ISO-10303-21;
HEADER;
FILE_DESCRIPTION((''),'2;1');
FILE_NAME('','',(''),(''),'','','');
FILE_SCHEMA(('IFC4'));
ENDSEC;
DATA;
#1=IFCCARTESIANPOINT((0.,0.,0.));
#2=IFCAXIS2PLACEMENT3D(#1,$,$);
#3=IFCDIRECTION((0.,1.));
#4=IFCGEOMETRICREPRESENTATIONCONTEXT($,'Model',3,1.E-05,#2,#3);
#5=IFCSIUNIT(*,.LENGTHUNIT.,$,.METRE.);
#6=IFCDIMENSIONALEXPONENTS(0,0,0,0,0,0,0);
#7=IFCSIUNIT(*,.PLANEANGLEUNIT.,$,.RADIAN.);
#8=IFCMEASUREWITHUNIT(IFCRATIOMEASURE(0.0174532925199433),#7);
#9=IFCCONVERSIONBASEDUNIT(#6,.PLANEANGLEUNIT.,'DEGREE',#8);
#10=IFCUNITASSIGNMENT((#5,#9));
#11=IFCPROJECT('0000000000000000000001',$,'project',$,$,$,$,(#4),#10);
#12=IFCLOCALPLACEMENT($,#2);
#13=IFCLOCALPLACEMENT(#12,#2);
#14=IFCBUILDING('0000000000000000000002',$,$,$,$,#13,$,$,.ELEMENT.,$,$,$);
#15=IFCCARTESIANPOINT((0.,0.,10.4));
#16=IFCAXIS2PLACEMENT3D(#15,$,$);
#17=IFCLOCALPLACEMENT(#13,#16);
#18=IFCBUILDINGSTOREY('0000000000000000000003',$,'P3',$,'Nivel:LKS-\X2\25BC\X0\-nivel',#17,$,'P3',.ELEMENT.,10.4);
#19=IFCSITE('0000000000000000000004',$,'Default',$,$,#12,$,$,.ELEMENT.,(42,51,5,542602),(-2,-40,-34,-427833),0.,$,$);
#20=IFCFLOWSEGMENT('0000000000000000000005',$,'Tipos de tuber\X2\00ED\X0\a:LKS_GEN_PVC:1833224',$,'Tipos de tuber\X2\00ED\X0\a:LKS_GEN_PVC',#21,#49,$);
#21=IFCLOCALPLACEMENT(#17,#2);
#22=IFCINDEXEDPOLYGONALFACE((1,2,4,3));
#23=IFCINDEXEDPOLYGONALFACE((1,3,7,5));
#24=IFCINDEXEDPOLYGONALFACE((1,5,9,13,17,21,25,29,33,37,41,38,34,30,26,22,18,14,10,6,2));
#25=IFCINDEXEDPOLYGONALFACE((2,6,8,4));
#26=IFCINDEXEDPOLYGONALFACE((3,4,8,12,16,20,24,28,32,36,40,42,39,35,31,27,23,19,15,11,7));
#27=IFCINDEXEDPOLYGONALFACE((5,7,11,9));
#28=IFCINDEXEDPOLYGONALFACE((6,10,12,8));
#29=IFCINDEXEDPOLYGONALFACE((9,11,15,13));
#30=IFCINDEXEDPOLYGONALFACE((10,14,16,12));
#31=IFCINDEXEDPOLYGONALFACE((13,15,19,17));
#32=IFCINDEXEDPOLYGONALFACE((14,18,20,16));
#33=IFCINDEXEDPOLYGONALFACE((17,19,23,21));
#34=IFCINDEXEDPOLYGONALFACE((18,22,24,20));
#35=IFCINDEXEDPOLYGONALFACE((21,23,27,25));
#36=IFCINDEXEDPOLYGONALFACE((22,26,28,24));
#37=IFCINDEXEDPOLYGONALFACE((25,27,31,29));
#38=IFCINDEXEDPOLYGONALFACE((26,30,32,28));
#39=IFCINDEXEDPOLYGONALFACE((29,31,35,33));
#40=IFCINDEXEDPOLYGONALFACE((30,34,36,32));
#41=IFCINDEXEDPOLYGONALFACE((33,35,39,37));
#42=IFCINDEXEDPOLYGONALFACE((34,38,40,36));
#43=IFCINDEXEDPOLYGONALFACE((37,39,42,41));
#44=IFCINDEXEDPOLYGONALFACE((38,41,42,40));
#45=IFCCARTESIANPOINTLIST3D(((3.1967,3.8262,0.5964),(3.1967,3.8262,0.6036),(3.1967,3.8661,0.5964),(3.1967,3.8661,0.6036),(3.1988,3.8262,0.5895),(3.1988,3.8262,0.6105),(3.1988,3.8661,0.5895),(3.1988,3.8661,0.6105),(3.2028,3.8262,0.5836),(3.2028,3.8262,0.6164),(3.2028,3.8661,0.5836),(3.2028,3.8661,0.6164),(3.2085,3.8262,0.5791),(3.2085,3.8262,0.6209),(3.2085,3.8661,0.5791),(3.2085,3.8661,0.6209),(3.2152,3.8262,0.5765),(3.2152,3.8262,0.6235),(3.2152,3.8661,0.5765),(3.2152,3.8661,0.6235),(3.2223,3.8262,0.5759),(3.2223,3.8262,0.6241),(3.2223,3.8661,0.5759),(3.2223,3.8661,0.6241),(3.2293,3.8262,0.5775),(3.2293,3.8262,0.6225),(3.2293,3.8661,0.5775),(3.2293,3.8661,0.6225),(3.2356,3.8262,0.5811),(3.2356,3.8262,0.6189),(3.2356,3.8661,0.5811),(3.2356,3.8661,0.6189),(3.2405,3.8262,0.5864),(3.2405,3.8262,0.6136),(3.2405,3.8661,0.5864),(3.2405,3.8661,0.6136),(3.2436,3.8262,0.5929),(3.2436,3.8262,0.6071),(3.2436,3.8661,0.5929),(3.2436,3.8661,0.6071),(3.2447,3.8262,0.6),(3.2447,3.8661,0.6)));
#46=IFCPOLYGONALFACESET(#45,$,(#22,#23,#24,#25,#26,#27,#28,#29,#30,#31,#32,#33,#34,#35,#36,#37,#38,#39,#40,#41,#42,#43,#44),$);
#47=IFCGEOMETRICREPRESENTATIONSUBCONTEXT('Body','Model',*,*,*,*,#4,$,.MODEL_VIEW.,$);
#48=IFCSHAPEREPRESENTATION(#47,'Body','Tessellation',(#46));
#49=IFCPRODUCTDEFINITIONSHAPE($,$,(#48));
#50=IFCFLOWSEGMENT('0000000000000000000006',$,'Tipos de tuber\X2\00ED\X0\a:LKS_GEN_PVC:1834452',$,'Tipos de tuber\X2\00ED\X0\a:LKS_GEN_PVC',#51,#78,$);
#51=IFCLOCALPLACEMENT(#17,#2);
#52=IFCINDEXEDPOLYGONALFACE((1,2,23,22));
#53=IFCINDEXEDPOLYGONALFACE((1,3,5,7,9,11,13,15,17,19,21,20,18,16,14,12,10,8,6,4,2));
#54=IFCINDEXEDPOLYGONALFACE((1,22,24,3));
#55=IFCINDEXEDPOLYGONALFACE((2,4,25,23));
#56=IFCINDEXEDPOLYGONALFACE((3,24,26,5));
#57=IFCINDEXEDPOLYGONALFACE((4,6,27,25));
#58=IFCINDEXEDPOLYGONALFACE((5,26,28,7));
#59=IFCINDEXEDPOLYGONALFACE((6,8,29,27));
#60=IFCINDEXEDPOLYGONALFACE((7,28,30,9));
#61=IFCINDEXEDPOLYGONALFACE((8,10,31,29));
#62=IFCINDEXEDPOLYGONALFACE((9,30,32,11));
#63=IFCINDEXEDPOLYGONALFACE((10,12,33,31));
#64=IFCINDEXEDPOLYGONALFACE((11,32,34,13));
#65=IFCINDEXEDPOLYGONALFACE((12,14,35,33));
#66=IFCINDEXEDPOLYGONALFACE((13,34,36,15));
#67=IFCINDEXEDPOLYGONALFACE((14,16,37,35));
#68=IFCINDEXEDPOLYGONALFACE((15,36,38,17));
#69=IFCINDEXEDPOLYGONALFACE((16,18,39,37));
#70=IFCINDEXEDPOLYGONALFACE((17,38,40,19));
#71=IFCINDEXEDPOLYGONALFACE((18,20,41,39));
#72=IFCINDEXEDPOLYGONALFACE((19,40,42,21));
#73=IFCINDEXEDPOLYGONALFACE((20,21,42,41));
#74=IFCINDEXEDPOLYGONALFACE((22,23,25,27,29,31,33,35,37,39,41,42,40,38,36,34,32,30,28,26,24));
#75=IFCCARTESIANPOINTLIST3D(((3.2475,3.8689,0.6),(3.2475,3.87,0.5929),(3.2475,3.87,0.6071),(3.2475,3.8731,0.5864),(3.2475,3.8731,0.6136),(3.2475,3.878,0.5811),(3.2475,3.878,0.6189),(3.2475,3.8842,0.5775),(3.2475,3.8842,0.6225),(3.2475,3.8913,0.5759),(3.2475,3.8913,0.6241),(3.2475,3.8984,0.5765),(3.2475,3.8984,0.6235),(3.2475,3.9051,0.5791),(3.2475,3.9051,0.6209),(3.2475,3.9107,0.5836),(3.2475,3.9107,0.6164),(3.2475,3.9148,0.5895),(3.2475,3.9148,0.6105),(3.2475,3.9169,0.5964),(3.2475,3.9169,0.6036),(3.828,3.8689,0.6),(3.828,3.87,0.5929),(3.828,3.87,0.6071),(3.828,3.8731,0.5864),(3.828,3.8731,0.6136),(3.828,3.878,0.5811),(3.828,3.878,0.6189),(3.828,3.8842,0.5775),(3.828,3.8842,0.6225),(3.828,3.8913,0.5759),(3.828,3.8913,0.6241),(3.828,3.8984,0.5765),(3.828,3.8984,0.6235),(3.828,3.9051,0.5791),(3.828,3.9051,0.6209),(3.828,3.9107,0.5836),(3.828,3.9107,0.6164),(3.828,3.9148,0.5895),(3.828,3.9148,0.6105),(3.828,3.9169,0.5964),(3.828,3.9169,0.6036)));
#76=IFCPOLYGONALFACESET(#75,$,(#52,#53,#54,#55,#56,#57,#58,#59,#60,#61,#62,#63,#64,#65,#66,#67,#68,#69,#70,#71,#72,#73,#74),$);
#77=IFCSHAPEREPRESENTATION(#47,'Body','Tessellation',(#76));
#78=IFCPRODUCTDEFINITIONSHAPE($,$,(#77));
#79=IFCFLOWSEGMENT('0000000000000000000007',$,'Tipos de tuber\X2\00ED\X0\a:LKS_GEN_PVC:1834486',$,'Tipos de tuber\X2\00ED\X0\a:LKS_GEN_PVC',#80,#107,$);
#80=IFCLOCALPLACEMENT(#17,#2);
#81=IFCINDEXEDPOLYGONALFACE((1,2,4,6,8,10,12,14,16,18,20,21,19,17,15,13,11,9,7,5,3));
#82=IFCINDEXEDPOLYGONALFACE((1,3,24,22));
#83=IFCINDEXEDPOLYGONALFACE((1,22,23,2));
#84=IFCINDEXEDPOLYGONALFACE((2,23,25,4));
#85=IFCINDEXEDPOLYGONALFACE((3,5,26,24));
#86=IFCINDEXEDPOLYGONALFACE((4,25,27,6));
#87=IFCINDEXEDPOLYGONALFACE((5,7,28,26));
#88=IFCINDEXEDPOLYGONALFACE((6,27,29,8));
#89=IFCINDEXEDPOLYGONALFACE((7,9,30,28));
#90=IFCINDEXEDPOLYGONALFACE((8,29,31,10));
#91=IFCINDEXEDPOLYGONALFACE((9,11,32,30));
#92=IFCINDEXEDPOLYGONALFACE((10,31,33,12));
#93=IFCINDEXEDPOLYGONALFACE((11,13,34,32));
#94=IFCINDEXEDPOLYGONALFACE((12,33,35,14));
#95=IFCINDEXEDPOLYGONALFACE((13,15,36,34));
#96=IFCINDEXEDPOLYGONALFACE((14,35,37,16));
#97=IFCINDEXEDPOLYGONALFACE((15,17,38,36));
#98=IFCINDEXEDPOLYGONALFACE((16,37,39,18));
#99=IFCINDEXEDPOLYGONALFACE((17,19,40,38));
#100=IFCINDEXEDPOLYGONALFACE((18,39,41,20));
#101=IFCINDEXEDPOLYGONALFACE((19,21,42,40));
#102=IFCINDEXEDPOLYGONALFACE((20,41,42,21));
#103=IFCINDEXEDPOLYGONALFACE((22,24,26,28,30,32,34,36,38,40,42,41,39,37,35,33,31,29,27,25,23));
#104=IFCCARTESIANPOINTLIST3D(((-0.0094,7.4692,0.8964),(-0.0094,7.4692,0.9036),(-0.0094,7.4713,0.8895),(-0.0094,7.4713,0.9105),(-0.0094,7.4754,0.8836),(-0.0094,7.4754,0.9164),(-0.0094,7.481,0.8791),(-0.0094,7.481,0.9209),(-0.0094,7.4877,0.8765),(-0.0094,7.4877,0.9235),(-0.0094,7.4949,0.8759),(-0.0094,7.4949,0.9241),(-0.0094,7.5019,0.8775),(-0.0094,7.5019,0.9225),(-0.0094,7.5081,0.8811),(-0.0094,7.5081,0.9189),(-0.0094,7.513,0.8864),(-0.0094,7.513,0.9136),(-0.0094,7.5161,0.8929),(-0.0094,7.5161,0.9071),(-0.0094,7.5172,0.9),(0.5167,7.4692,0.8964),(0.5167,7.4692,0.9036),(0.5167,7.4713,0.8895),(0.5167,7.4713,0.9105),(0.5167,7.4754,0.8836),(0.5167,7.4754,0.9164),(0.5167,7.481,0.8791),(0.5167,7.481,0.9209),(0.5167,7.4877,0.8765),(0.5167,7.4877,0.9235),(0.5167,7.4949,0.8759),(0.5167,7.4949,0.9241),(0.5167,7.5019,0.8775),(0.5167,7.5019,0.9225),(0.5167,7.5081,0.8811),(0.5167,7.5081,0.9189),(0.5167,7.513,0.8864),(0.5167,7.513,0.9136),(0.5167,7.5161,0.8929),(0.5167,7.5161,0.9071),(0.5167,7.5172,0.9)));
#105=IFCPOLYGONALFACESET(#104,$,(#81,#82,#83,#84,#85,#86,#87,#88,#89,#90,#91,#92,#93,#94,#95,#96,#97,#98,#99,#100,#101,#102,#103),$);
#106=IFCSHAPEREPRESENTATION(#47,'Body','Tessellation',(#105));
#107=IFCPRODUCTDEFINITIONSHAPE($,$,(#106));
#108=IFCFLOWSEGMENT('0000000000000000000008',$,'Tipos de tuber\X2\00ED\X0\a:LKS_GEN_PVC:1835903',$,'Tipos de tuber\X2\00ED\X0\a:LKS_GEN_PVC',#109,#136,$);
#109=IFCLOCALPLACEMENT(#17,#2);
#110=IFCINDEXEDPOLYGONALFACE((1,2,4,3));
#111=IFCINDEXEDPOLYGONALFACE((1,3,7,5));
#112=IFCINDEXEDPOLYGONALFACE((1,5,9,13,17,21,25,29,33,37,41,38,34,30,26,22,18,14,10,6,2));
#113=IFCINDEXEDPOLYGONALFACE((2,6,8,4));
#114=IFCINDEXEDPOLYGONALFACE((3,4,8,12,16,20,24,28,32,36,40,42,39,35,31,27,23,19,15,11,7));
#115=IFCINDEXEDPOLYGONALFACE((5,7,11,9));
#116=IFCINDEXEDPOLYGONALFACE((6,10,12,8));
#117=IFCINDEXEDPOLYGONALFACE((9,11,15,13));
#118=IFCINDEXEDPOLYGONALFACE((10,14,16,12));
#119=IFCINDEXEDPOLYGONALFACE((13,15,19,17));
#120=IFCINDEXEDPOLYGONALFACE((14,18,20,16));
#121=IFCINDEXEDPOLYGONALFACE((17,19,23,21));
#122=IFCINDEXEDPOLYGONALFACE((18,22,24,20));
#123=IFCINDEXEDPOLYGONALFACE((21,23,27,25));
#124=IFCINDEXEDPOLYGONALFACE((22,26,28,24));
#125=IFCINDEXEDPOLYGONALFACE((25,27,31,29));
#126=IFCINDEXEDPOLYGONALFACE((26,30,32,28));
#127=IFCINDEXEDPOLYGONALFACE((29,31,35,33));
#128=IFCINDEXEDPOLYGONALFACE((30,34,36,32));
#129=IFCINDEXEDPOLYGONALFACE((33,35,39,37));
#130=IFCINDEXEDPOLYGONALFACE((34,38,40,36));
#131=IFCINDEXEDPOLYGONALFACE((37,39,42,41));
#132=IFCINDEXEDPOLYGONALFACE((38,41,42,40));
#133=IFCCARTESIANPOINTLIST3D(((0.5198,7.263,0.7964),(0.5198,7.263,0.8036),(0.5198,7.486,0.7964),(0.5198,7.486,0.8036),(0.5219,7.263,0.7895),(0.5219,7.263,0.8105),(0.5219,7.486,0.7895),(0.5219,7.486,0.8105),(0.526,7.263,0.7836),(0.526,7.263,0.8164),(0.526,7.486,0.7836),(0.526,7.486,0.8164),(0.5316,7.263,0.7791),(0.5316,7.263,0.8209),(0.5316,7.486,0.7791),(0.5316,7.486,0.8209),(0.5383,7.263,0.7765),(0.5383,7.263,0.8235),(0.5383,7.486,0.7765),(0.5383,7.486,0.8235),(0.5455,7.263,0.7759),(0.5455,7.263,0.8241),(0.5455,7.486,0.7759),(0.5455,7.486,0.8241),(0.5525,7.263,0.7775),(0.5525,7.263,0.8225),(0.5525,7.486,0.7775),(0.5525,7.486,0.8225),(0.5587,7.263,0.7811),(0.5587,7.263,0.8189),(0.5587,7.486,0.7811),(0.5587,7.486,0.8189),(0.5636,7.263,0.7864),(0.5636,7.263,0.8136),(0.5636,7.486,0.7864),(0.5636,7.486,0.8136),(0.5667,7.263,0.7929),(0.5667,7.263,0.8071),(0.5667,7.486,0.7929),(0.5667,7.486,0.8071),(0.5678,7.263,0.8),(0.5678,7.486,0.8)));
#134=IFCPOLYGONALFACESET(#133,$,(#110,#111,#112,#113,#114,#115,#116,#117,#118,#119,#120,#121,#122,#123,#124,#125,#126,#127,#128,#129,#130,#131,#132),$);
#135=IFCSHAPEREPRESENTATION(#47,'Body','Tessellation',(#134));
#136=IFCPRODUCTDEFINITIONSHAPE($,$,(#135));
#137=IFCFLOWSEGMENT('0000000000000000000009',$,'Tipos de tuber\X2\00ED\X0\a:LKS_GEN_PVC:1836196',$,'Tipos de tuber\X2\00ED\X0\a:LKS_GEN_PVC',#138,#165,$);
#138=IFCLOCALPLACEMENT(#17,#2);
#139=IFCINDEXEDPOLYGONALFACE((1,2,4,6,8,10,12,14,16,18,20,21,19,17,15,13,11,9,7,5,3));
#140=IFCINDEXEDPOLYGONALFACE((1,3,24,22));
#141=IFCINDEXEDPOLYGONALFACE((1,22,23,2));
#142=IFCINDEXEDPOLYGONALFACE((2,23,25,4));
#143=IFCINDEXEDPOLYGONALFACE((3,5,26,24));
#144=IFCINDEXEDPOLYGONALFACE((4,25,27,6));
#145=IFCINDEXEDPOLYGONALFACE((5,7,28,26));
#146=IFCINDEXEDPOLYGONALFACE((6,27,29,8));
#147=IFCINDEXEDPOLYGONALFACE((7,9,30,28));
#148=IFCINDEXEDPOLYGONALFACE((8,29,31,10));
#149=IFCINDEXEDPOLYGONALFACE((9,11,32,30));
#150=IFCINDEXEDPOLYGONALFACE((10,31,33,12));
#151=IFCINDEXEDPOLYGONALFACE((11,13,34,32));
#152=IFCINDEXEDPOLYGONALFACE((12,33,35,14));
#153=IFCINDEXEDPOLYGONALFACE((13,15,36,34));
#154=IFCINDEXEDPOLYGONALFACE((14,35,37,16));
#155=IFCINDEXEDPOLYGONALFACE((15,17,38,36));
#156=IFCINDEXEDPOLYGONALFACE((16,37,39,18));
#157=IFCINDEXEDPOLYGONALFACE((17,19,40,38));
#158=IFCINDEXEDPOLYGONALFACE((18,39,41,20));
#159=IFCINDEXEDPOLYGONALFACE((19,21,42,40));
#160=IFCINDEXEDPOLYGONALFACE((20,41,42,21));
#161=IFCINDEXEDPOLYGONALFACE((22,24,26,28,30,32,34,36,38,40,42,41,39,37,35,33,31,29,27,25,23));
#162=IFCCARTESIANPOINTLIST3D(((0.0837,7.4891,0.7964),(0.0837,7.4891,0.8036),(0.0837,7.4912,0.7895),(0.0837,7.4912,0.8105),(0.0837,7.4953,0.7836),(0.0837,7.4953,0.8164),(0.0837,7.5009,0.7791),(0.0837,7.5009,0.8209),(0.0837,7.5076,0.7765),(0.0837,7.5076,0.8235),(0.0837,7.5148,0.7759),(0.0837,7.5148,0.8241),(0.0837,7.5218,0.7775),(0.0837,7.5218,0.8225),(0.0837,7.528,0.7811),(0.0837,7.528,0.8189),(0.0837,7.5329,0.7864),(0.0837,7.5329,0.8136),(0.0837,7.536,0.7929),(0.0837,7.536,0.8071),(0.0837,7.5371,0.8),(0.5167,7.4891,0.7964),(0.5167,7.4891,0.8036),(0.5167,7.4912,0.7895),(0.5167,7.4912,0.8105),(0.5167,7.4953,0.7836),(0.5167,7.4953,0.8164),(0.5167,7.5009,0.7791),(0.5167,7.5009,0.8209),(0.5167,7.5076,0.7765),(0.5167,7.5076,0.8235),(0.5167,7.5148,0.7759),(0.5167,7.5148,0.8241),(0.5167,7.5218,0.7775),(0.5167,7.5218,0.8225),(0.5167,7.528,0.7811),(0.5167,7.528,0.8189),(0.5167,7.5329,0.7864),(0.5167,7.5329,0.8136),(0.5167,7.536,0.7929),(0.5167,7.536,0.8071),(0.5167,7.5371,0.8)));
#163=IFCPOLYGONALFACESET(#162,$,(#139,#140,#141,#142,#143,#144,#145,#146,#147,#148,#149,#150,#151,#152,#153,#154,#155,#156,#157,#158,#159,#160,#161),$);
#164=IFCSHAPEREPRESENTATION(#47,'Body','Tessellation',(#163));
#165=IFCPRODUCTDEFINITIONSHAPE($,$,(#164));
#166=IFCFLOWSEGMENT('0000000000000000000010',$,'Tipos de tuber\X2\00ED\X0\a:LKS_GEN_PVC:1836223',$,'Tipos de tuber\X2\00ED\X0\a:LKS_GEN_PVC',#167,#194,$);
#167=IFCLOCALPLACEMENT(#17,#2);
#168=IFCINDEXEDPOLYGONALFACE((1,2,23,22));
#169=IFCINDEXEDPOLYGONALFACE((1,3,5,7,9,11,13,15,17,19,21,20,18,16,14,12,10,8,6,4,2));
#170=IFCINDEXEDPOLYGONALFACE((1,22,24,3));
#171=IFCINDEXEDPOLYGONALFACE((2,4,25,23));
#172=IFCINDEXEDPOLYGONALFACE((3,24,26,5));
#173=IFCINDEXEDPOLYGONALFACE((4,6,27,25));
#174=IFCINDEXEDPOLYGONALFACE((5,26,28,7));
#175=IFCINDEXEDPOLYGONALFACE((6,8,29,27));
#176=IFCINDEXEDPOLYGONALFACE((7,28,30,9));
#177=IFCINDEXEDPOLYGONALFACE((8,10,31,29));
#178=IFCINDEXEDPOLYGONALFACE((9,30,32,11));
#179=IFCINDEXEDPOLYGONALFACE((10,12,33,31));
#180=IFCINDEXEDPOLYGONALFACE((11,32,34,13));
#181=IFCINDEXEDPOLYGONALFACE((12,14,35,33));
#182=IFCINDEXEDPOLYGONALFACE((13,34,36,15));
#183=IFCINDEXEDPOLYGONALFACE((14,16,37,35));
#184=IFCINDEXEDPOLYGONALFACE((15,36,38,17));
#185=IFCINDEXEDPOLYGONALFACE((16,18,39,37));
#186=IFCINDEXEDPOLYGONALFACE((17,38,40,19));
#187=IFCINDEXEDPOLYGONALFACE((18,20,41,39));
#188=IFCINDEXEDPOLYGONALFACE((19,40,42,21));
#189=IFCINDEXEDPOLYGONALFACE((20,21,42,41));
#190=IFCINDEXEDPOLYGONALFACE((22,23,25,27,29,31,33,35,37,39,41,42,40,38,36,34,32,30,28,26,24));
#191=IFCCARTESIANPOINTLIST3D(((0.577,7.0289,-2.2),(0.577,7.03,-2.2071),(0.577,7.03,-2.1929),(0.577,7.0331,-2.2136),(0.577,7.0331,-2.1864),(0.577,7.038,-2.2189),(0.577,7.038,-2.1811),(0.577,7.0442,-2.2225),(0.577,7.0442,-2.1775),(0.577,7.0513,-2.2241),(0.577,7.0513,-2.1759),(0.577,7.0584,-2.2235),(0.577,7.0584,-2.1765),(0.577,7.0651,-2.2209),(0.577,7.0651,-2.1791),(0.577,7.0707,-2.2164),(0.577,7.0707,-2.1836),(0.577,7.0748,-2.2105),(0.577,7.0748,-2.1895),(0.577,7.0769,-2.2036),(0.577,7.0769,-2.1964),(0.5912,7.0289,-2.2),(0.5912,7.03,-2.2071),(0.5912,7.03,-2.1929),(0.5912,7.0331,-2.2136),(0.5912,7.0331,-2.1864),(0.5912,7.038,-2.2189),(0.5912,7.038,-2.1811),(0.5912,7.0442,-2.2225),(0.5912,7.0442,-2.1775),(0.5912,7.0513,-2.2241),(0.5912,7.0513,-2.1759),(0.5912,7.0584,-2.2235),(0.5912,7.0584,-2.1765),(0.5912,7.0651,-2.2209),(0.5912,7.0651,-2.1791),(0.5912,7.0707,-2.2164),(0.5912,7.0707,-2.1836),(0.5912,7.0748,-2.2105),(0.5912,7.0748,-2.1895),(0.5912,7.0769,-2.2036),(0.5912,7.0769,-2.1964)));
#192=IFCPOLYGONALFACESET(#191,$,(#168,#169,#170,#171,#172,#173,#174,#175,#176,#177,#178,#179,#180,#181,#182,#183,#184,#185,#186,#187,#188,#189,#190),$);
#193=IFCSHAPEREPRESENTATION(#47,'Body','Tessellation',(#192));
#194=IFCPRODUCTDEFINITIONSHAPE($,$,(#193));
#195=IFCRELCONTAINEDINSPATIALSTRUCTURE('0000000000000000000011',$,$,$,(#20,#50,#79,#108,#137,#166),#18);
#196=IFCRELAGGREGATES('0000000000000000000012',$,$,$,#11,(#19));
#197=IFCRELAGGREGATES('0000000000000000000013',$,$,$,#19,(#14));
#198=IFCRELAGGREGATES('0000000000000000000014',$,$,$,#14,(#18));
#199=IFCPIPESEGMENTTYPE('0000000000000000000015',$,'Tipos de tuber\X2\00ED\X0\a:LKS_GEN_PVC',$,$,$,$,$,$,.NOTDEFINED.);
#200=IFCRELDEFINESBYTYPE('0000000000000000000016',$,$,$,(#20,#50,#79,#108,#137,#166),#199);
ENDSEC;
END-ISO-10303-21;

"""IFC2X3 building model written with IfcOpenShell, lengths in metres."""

from ifc_helpers import new_model, entity, si_unit, converted_unit, direction, frame, frame_2d, origin, origin_2d_with_axis, place, context, subcontext, project, spatial, circle, extrude, type_object, element, save


model = new_model("IFC2X3")

# Units and contexts
model_context = context("Model", 3, precision=1e-05, world=origin(), true_north=direction((0.0, 1.0)))
body_context = subcontext(model_context, "Body", "Model", "MODEL_VIEW")
ifc_project = project(units=[si_unit("LENGTHUNIT", "METRE"), converted_unit("PLANEANGLEUNIT", "DEGREE", entity("IfcRatioMeasure", 0.0174532925199433), si_unit("PLANEANGLEUNIT", "RADIAN"), dimensions=[0, 0, 0, 0, 0, 0, 0])], contexts=[model_context])

# Site, building, storey
site_placement = place(None, origin())
site = spatial("IfcSite", under=ifc_project, at=site_placement, Name="Default", CompositionType="ELEMENT", RefLatitude=(42, 51, 5, 542602), RefLongitude=(-2, -40, -34, -427833), RefElevation=0.0)
building_placement = place(site_placement, origin())
building = spatial("IfcBuilding", under=site, at=building_placement, CompositionType="ELEMENT")
storey_placement = place(building_placement, frame((0.0, 0.0, 10.4)))
storey = spatial("IfcBuildingStorey", under=building, at=storey_placement, Name="P3", ObjectType="Nivel:LKS-▼-nivel", LongName="P3", CompositionType="ELEMENT", Elevation=10.4)

# Flow segments
pipe_segment_type_1 = type_object("IfcPipeSegmentType", Name="Tipos de tubería:LKS_GEN_PVC", PredefinedType="NOTDEFINED")
flow_segment_1_placement = place(storey_placement, origin())
element("IfcFlowSegment", 1, at=flow_segment_1_placement, inside=storey, type_object=pipe_segment_type_1, Name="Tipos de tubería:LKS_GEN_PVC:1833224", ObjectType="Tipos de tubería:LKS_GEN_PVC", context=body_context, shape_type="SweptSolid", body=[
    extrude(circle(Radius=0.0241, at=origin_2d_with_axis()), frame((3.2205, 3.8262, 0.6), z_axis=(0.0, 1.0, 0.0), x_axis=(1.0, 0.0, 0.0)), (0.0, 0.0, 1.0), 0.0398),
])
flow_segment_2_placement = place(storey_placement, origin())
element("IfcFlowSegment", 2, at=flow_segment_2_placement, inside=storey, type_object=pipe_segment_type_1, Name="Tipos de tubería:LKS_GEN_PVC:1834452", ObjectType="Tipos de tubería:LKS_GEN_PVC", context=body_context, shape_type="SweptSolid", body=[
    extrude(circle(Radius=0.0241, at=origin_2d_with_axis()), frame((3.2475, 3.8931, 0.6), z_axis=(1.0, 0.0, 0.0), x_axis=(0.0, -1.0, 0.0)), (0.0, 0.0, 1.0), 0.5805),
])
flow_segment_3_placement = place(storey_placement, origin())
element("IfcFlowSegment", 3, at=flow_segment_3_placement, inside=storey, type_object=pipe_segment_type_1, Name="Tipos de tubería:LKS_GEN_PVC:1834486", ObjectType="Tipos de tubería:LKS_GEN_PVC", context=body_context, shape_type="SweptSolid", body=[
    extrude(circle(Radius=0.0241, at=frame_2d((0.0, 0.0), x_axis=(1.0, 0.0))), frame((-0.0094, 7.4931, 0.9), z_axis=(1.0, 0.0, 0.0), x_axis=(0.0, 1.0, 0.0)), (0.0, 0.0, 1.0), 0.526),
])
flow_segment_4_placement = place(storey_placement, origin())
element("IfcFlowSegment", 4, at=flow_segment_4_placement, inside=storey, type_object=pipe_segment_type_1, Name="Tipos de tubería:LKS_GEN_PVC:1835903", ObjectType="Tipos de tubería:LKS_GEN_PVC", context=body_context, shape_type="SweptSolid", body=[
    extrude(circle(Radius=0.0241, at=frame_2d((0.0, 0.0), x_axis=(1.0, 0.0))), frame((0.5437, 7.263, 0.8), z_axis=(0.0, 1.0, 0.0), x_axis=(1.0, 0.0, 0.0)), (0.0, 0.0, 1.0), 0.223),
])
flow_segment_5_placement = place(storey_placement, origin())
element("IfcFlowSegment", 5, at=flow_segment_5_placement, inside=storey, type_object=pipe_segment_type_1, Name="Tipos de tubería:LKS_GEN_PVC:1836196", ObjectType="Tipos de tubería:LKS_GEN_PVC", context=body_context, shape_type="SweptSolid", body=[
    extrude(circle(Radius=0.0241, at=frame_2d((0.0, 0.0), x_axis=(1.0, 0.0))), frame((0.0837, 7.513, 0.8), z_axis=(1.0, 0.0, 0.0), x_axis=(0.0, 1.0, 0.0)), (0.0, 0.0, 1.0), 0.433),
])
flow_segment_6_placement = place(storey_placement, origin())
element("IfcFlowSegment", 6, at=flow_segment_6_placement, inside=storey, type_object=pipe_segment_type_1, Name="Tipos de tubería:LKS_GEN_PVC:1836223", ObjectType="Tipos de tubería:LKS_GEN_PVC", context=body_context, shape_type="SweptSolid", body=[
    extrude(circle(Radius=0.0241, at=origin_2d_with_axis()), frame((0.577, 7.0531, -2.2), z_axis=(1.0, 0.0, 0.0), x_axis=(0.0, -1.0, 0.0)), (0.0, 0.0, 1.0), 0.0142),
])

save(model, "model.ifc")
